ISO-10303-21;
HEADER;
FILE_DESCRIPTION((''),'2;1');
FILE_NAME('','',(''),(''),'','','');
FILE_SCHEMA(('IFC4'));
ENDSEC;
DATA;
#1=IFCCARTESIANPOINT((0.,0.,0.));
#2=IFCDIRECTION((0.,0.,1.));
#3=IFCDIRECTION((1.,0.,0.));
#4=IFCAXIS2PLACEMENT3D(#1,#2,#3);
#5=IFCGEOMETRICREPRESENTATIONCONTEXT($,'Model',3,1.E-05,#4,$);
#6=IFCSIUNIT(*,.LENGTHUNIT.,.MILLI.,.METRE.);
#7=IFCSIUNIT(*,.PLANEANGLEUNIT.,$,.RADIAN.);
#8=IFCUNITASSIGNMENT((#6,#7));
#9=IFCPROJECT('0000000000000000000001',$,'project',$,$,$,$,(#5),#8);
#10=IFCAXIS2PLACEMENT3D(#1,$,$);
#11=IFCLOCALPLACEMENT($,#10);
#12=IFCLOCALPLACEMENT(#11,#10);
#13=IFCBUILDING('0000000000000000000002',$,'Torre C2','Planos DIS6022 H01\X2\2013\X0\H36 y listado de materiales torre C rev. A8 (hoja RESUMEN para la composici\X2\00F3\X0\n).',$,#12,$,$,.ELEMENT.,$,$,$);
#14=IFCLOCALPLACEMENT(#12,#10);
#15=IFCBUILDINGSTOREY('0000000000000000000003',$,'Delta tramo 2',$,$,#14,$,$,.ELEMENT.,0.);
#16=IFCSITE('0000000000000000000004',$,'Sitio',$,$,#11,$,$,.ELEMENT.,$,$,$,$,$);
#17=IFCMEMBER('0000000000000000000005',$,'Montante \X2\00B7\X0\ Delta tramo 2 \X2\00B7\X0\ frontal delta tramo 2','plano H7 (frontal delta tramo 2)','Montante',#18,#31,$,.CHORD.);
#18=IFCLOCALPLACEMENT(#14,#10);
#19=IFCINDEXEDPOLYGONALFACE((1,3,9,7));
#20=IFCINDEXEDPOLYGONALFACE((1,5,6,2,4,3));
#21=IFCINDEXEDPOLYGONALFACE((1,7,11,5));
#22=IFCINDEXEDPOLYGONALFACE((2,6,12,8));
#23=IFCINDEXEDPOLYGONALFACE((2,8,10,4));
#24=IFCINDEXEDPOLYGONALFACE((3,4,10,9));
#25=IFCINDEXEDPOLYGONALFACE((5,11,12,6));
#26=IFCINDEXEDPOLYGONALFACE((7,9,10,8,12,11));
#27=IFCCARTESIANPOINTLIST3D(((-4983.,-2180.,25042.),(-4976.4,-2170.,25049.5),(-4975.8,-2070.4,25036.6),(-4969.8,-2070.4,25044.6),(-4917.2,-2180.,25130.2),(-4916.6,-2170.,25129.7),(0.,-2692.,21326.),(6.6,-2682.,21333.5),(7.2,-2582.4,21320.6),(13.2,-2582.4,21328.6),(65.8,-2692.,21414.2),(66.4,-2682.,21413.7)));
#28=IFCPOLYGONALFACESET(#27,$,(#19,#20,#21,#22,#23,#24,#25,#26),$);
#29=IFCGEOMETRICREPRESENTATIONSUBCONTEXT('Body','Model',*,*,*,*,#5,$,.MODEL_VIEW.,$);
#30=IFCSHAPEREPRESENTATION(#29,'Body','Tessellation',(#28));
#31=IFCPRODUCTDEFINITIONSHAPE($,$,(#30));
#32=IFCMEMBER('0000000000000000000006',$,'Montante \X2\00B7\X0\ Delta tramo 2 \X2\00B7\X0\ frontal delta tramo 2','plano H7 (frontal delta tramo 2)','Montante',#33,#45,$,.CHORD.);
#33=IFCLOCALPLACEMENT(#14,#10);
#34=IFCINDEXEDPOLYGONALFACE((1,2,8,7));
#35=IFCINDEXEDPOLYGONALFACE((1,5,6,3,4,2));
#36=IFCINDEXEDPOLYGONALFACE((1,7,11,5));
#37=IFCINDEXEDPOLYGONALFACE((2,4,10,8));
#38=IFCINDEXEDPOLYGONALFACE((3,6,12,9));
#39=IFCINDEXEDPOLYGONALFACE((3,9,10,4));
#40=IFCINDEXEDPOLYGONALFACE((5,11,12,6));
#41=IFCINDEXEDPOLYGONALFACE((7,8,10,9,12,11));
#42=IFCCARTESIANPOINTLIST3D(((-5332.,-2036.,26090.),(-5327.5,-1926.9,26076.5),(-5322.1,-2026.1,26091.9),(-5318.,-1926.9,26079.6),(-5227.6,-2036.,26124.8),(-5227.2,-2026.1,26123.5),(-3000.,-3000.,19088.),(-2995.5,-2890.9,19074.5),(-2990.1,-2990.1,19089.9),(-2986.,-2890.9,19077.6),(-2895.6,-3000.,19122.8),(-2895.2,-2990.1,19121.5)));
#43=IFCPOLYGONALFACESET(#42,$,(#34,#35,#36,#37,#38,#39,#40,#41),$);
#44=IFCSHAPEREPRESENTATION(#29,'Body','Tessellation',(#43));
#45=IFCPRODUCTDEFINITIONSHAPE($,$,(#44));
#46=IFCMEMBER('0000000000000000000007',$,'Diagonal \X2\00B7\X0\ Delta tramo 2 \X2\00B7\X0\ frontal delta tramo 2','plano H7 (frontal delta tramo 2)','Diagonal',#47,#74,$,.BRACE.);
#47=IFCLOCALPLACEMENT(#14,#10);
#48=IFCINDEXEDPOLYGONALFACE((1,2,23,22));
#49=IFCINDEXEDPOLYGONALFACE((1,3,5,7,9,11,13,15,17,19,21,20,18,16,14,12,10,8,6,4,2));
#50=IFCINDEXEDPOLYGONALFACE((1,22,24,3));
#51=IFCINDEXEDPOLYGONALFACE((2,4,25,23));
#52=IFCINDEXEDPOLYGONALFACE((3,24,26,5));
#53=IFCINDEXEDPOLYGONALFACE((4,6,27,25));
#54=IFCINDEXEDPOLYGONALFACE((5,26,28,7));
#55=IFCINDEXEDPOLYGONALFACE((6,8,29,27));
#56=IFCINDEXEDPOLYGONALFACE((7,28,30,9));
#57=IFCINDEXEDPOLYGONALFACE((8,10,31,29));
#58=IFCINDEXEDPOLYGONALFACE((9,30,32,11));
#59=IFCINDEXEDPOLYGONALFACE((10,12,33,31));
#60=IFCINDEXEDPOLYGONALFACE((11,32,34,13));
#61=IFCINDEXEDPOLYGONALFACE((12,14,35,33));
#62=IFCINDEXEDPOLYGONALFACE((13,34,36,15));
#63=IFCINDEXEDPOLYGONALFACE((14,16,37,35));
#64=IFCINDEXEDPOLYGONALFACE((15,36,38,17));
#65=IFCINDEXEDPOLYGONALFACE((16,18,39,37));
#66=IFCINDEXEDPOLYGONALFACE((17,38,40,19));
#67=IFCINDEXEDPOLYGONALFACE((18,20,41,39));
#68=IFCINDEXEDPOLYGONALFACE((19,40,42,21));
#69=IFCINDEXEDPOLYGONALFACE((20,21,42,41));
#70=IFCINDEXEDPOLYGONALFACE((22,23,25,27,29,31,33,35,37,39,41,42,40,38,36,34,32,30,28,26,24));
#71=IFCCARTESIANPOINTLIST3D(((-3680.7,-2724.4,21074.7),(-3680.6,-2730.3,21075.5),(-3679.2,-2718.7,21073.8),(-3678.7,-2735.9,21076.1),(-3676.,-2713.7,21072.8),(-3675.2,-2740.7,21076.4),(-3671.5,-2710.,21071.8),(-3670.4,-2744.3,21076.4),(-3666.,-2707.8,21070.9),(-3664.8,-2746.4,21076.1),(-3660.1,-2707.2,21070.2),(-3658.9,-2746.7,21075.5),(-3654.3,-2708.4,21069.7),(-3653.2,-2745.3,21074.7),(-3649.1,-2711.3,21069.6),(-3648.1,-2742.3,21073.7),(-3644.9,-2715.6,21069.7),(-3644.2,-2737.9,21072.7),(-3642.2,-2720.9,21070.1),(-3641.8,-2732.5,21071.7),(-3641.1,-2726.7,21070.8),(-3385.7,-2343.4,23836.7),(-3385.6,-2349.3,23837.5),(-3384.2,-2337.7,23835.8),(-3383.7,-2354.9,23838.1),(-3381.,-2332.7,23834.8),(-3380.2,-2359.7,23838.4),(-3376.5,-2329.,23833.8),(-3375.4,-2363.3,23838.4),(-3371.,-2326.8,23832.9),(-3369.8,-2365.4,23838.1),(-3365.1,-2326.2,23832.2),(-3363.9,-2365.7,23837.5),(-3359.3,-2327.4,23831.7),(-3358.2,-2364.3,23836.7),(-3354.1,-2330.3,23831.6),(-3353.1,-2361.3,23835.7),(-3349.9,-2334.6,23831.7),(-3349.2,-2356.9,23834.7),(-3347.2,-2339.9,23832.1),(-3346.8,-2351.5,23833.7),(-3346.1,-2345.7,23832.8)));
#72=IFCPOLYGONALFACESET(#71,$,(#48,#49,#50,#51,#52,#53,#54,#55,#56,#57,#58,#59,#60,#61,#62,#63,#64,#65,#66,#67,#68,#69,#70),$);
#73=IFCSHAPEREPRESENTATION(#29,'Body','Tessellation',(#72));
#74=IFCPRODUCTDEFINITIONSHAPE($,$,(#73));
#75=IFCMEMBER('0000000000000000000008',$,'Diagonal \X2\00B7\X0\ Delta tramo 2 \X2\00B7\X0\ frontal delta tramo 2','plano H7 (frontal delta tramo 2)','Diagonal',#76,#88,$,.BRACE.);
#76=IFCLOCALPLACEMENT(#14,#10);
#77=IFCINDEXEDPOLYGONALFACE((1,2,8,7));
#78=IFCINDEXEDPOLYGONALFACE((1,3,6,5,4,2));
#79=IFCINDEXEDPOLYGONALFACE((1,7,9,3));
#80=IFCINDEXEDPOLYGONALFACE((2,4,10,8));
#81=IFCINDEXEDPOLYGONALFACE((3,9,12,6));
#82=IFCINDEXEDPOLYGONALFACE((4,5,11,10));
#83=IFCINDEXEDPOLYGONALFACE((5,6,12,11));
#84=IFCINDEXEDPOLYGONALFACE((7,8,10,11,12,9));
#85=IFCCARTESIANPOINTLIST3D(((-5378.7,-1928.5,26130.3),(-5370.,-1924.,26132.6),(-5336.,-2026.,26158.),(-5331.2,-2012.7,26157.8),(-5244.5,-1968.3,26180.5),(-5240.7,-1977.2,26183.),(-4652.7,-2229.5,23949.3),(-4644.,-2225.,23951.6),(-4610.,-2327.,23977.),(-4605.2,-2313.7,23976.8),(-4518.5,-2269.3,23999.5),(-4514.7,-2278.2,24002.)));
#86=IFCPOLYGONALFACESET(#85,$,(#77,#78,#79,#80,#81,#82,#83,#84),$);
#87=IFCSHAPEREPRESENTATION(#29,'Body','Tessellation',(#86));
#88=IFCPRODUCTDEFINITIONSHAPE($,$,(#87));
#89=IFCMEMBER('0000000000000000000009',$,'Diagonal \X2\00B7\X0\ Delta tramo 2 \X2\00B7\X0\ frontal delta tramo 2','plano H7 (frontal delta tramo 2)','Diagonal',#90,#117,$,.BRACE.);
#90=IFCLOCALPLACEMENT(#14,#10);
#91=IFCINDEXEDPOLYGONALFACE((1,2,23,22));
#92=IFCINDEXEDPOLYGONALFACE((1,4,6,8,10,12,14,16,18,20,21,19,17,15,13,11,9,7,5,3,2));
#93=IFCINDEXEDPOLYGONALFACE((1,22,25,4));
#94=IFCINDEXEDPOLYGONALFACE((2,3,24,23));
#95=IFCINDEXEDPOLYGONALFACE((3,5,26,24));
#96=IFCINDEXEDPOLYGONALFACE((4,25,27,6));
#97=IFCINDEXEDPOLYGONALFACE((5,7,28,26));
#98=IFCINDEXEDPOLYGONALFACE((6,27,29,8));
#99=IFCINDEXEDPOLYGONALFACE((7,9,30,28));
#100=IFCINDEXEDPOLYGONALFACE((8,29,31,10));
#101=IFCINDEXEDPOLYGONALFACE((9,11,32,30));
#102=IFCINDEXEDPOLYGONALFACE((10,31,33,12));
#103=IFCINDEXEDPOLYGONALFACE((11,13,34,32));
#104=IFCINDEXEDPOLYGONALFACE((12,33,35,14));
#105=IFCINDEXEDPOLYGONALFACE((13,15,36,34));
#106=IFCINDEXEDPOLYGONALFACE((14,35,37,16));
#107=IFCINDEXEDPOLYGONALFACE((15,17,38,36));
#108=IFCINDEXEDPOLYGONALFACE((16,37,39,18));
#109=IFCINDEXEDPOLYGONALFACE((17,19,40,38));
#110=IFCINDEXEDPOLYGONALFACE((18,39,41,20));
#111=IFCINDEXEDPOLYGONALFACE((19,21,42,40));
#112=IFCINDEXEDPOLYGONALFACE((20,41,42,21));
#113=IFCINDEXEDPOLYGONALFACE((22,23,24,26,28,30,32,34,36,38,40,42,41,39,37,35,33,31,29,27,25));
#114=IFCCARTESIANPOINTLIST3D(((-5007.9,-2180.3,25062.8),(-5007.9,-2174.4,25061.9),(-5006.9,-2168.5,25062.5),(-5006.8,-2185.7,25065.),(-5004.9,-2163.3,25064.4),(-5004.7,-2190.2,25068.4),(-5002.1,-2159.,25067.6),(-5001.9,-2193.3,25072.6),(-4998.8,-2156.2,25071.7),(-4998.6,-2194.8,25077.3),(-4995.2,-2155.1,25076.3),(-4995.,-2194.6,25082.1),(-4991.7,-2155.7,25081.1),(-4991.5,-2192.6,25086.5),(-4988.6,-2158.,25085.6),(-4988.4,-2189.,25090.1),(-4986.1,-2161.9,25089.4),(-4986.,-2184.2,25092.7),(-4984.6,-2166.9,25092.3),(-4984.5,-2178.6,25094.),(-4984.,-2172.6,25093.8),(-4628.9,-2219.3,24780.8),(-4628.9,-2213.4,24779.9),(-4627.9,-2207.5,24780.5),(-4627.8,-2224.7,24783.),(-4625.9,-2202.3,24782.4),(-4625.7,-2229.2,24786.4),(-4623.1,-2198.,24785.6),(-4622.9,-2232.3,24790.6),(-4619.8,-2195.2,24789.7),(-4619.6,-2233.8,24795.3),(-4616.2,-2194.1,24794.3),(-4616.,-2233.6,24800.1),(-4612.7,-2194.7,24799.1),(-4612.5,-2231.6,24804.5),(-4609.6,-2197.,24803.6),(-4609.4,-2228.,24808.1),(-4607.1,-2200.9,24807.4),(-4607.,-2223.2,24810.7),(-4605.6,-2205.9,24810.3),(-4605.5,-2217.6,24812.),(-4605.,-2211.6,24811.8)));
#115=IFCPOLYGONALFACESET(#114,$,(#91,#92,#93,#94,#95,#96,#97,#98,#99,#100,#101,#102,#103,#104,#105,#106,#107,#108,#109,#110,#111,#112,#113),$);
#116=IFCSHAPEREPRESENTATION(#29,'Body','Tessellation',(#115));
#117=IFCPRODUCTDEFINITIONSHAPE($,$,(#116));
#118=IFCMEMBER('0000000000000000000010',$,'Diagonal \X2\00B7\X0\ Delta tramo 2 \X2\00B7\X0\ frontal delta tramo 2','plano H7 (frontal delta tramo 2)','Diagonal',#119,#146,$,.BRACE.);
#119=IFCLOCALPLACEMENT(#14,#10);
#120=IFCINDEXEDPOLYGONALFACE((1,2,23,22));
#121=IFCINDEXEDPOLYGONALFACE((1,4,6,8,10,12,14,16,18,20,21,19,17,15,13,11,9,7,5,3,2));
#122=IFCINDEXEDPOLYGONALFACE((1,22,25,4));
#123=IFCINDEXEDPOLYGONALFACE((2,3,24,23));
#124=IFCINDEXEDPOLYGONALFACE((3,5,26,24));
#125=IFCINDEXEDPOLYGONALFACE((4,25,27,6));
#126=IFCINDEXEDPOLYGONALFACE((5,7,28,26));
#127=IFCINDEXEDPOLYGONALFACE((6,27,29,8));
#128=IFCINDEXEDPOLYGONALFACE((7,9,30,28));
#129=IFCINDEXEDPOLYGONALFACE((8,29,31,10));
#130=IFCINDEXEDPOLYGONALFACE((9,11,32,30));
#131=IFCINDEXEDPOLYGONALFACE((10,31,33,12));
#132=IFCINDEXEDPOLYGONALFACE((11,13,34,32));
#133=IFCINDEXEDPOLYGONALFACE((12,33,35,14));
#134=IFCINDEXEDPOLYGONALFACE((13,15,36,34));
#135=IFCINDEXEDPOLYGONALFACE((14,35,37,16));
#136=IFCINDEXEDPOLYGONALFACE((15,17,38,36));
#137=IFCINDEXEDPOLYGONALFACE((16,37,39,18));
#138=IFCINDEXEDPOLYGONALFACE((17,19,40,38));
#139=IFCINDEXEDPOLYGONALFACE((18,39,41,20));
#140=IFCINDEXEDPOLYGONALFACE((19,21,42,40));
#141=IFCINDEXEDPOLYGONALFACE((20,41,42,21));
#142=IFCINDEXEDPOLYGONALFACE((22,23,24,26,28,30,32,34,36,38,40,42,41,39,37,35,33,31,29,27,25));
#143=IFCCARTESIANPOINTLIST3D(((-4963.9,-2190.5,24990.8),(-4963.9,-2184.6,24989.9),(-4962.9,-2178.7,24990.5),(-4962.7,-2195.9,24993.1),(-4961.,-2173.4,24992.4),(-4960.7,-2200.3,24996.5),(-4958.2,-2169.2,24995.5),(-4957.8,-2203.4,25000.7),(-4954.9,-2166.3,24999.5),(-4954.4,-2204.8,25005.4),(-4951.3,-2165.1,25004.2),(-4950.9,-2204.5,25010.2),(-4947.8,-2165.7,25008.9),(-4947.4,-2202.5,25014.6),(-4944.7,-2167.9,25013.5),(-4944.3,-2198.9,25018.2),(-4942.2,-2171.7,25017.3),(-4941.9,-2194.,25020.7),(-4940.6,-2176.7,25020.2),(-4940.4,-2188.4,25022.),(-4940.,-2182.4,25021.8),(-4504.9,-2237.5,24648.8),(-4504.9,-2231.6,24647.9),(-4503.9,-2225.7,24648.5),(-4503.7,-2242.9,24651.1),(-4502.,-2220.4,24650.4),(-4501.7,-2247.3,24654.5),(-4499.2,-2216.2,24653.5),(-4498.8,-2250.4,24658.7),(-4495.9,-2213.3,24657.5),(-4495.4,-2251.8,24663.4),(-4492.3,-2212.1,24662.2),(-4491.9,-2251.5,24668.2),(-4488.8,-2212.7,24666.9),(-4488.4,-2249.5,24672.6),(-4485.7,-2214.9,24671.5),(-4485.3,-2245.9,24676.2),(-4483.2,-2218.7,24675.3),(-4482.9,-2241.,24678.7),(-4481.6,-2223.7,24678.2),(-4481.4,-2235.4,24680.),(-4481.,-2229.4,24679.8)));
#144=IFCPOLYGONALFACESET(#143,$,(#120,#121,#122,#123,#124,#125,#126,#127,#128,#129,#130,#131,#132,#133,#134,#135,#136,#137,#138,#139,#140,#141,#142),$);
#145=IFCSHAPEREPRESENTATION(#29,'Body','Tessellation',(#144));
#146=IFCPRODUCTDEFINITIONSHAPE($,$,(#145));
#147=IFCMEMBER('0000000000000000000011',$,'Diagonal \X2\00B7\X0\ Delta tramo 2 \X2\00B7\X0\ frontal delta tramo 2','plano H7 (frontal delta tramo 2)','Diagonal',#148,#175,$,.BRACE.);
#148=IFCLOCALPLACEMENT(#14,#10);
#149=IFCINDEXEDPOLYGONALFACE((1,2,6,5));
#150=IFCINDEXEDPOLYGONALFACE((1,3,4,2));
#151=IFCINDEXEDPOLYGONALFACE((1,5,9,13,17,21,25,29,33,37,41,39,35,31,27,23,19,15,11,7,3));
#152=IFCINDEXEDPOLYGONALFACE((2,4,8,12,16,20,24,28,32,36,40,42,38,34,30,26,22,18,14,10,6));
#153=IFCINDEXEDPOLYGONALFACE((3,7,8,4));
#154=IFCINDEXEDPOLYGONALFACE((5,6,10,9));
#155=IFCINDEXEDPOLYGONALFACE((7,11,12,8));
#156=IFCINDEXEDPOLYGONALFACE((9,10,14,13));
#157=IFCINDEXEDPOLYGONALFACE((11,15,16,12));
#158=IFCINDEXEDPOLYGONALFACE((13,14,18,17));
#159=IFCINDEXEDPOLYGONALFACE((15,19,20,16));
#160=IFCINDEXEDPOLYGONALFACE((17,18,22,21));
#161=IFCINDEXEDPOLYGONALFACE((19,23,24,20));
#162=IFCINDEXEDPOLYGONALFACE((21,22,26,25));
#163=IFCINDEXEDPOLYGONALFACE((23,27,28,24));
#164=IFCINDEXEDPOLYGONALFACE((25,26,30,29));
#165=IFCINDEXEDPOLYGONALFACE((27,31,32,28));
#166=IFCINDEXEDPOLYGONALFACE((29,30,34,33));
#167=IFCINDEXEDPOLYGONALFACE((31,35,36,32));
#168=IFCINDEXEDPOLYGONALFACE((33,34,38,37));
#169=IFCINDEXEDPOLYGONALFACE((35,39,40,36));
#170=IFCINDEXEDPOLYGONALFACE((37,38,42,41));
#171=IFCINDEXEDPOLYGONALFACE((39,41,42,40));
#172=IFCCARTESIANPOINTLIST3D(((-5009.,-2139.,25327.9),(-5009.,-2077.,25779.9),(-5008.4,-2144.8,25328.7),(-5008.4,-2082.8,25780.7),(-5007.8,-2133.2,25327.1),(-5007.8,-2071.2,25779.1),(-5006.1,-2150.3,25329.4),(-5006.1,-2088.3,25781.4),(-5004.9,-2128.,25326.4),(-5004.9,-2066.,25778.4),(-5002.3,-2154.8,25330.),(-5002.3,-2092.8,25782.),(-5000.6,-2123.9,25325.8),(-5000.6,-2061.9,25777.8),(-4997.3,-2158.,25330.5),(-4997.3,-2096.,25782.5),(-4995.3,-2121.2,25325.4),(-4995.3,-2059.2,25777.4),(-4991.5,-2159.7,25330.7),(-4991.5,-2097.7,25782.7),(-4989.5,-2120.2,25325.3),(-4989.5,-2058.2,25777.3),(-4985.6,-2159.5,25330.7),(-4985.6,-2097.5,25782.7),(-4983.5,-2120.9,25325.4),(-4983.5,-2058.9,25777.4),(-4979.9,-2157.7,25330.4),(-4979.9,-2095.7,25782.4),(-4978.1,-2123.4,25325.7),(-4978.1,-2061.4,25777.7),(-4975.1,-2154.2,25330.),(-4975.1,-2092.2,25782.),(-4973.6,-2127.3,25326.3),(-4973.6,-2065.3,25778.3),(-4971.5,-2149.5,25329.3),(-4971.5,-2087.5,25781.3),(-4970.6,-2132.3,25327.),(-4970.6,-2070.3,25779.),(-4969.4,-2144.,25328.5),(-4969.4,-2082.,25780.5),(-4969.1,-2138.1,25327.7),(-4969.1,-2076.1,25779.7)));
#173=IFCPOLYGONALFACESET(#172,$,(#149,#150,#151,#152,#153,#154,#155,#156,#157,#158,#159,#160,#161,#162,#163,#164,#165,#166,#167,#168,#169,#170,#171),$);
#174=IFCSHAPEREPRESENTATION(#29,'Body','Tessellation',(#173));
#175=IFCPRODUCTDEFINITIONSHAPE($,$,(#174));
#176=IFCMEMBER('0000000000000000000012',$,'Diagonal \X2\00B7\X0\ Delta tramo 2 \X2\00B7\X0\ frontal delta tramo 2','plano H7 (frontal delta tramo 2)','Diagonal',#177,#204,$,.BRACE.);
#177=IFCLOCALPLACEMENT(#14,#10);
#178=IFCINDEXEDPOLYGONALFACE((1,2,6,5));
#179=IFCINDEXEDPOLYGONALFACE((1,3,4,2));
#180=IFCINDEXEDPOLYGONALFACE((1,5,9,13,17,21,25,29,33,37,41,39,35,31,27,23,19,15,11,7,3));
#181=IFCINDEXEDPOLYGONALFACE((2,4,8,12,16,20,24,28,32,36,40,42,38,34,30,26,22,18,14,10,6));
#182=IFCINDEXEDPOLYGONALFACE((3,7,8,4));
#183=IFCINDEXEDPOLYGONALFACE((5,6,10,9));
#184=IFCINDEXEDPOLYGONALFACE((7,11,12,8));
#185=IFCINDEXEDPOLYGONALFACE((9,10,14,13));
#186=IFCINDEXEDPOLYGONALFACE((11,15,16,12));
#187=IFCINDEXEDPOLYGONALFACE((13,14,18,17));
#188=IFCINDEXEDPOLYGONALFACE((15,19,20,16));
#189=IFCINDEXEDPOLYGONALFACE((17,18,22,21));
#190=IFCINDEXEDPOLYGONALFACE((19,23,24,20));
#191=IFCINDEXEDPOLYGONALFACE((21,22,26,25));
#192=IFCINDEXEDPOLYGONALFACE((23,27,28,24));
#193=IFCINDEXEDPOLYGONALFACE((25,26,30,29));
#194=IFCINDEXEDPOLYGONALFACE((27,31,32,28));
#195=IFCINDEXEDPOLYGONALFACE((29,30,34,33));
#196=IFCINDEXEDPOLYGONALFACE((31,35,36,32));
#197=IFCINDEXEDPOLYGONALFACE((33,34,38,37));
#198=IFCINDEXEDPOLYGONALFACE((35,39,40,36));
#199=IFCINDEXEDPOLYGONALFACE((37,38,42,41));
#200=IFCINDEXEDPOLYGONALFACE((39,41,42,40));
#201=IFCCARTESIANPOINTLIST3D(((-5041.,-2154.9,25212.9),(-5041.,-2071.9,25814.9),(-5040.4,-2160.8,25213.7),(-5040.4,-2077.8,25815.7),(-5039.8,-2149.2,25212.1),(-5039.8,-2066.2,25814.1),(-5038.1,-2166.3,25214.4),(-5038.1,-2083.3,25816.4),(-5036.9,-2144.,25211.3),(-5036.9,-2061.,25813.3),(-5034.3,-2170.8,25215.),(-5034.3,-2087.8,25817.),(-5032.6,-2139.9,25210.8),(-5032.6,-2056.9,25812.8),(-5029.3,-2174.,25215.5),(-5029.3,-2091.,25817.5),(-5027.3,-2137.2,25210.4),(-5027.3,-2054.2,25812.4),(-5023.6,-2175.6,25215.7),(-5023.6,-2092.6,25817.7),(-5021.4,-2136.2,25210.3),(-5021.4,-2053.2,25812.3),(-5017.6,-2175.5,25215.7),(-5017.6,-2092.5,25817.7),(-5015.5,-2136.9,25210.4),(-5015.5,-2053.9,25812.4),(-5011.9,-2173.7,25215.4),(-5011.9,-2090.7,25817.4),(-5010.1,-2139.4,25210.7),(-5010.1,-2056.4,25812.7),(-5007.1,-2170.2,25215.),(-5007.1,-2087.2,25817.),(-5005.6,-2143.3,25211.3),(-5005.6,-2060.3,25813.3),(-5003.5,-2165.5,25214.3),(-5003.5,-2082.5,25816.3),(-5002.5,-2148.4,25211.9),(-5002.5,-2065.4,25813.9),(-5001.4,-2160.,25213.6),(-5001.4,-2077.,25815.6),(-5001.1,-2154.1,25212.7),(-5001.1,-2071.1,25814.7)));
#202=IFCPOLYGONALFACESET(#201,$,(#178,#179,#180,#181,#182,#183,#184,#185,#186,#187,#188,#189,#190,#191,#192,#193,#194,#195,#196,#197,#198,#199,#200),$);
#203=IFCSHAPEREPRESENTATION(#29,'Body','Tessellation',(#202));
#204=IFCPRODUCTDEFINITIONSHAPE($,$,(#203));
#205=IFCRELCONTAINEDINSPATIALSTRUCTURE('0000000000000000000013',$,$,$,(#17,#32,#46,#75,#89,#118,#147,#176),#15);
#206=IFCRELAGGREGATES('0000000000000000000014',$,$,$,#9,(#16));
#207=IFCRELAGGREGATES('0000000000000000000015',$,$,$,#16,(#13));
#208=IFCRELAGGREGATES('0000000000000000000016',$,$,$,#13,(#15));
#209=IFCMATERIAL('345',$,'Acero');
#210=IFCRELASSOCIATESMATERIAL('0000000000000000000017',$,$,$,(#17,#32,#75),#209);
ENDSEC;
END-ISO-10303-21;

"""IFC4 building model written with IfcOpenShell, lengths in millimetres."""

from ifc_helpers import new_model, si_unit, frame, frame_2d, origin, origin_with_axes, place, context, subcontext, project, spatial, circle, l_section, extrude, material, element, save


model = new_model("IFC4")

# Units and contexts
model_context = context("Model", 3, precision=1e-05, world=origin_with_axes())
body_context = subcontext(model_context, "Body", "Model", "MODEL_VIEW")
ifc_project = project(units=[si_unit("LENGTHUNIT", "METRE", prefix="MILLI"), si_unit("PLANEANGLEUNIT", "RADIAN")], contexts=[model_context])

# Site, building, storey
site_placement = place(None, origin())
site = spatial("IfcSite", under=ifc_project, at=site_placement, Name="Sitio", CompositionType="ELEMENT")
building_placement = place(site_placement, origin())
building = spatial("IfcBuilding", under=site, at=building_placement, Name="Torre C2", Description="Planos DIS6022 H01–H36 y listado de materiales torre C rev. A8 (hoja RESUMEN para la composición).", CompositionType="ELEMENT")
storey_placement = place(building_placement, origin())
storey = spatial("IfcBuildingStorey", under=building, at=storey_placement, Name="Delta tramo 2", CompositionType="ELEMENT", Elevation=0.0)

# Members
ifc_material_1 = material(Name="345", Category="Acero")
member_1_placement = place(storey_placement, frame((-4983.0, -2180.0, 25042.0), z_axis=(0.798932, -0.08209, -0.595792), x_axis=(0.065806, 0.996625, -0.049074)))
element("IfcMember", 1, at=member_1_placement, inside=storey, material=ifc_material_1, Name="Montante · Delta tramo 2 · frontal delta tramo 2", Description="plano H7 (frontal delta tramo 2)", ObjectType="Montante", PredefinedType="CHORD", context=body_context, shape_type="SweptSolid", body=[
    extrude(l_section(Depth=110.0, Width=110.0, Thickness=10.0, at=frame_2d((55.0, 55.0))), None, (0.0, 0.0, 1.0), 6237.1),
])
member_2_placement = place(storey_placement, frame((-5332.0, -2036.0, 26090.0), z_axis=(0.313322, -0.129521, -0.940773), x_axis=(0.040926, 0.991577, -0.122885)))
element("IfcMember", 2, at=member_2_placement, inside=storey, material=ifc_material_1, Name="Montante · Delta tramo 2 · frontal delta tramo 2", Description="plano H7 (frontal delta tramo 2)", ObjectType="Montante", PredefinedType="CHORD", context=body_context, shape_type="SweptSolid", body=[
    extrude(l_section(Depth=110.0, Width=110.0, Thickness=10.0, at=frame_2d((55.0, 55.0))), None, (0.0, 0.0, 1.0), 7442.8),
])
member_3_placement = place(storey_placement, frame((-3366.0, -2346.0, 23835.0), z_axis=(-0.105217, -0.135891, -0.985121), x_axis=(0.804453, 0.570742, -0.164651)))
element("IfcMember", 3, at=member_3_placement, inside=storey, Name="Diagonal · Delta tramo 2 · frontal delta tramo 2", Description="plano H7 (frontal delta tramo 2)", ObjectType="Diagonal", PredefinedType="BRACE", context=body_context, shape_type="SweptSolid", body=[
    extrude(circle(Radius=20.0), None, (0.0, 0.0, 1.0), 2803.7),
])
member_4_placement = place(storey_placement, frame((-4610.0, -2327.0, 23977.0), z_axis=(-0.313163, 0.129837, 0.940782), x_axis=(0.866801, 0.443846, 0.227281)))
element("IfcMember", 4, at=member_4_placement, inside=storey, material=ifc_material_1, Name="Diagonal · Delta tramo 2 · frontal delta tramo 2", Description="plano H7 (frontal delta tramo 2)", ObjectType="Diagonal", PredefinedType="BRACE", context=body_context, shape_type="SweptSolid", body=[
    extrude(l_section(Depth=110.0, Width=110.0, Thickness=10.0, at=frame_2d((55.0, 55.0))), None, (0.0, 0.0, 1.0), 2318.3),
])
member_5_placement = place(storey_placement, frame((-4996.0, -2175.0, 25078.0), z_axis=(0.79956, -0.082277, -0.594923), x_axis=(0.493139, 0.655346, 0.572132)))
element("IfcMember", 5, at=member_5_placement, inside=storey, Name="Diagonal · Delta tramo 2 · frontal delta tramo 2", Description="plano H7 (frontal delta tramo 2)", ObjectType="Diagonal", PredefinedType="BRACE", context=body_context, shape_type="SweptSolid", body=[
    extrude(circle(Radius=20.0), None, (0.0, 0.0, 1.0), 474.0),
])
member_6_placement = place(storey_placement, frame((-4952.0, -2185.0, 25006.0), z_axis=(0.799193, -0.081835, -0.595477), x_axis=(0.48996, 0.662562, 0.566524)))
element("IfcMember", 6, at=member_6_placement, inside=storey, Name="Diagonal · Delta tramo 2 · frontal delta tramo 2", Description="plano H7 (frontal delta tramo 2)", ObjectType="Diagonal", PredefinedType="BRACE", context=body_context, shape_type="SweptSolid", body=[
    extrude(circle(Radius=20.0), None, (0.0, 0.0, 1.0), 574.3),
])
member_7_placement = place(storey_placement, frame((-4989.0, -2140.0, 25328.0), z_axis=(0.0, 0.135896, 0.990723), x_axis=(0.922374, 0.382714, -0.052496)))
element("IfcMember", 7, at=member_7_placement, inside=storey, Name="Diagonal · Delta tramo 2 · frontal delta tramo 2", Description="plano H7 (frontal delta tramo 2)", ObjectType="Diagonal", PredefinedType="BRACE", context=body_context, shape_type="SweptSolid", body=[
    extrude(circle(Radius=20.0), None, (0.0, 0.0, 1.0), 456.2),
])
member_8_placement = place(storey_placement, frame((-5021.0, -2156.0, 25213.0), z_axis=(0.0, 0.136582, 0.990629), x_axis=(0.922907, 0.381415, -0.052587)))
element("IfcMember", 8, at=member_8_placement, inside=storey, Name="Diagonal · Delta tramo 2 · frontal delta tramo 2", Description="plano H7 (frontal delta tramo 2)", ObjectType="Diagonal", PredefinedType="BRACE", context=body_context, shape_type="SweptSolid", body=[
    extrude(circle(Radius=20.0), None, (0.0, 0.0, 1.0), 607.7),
])

save(model, "model.ifc")
